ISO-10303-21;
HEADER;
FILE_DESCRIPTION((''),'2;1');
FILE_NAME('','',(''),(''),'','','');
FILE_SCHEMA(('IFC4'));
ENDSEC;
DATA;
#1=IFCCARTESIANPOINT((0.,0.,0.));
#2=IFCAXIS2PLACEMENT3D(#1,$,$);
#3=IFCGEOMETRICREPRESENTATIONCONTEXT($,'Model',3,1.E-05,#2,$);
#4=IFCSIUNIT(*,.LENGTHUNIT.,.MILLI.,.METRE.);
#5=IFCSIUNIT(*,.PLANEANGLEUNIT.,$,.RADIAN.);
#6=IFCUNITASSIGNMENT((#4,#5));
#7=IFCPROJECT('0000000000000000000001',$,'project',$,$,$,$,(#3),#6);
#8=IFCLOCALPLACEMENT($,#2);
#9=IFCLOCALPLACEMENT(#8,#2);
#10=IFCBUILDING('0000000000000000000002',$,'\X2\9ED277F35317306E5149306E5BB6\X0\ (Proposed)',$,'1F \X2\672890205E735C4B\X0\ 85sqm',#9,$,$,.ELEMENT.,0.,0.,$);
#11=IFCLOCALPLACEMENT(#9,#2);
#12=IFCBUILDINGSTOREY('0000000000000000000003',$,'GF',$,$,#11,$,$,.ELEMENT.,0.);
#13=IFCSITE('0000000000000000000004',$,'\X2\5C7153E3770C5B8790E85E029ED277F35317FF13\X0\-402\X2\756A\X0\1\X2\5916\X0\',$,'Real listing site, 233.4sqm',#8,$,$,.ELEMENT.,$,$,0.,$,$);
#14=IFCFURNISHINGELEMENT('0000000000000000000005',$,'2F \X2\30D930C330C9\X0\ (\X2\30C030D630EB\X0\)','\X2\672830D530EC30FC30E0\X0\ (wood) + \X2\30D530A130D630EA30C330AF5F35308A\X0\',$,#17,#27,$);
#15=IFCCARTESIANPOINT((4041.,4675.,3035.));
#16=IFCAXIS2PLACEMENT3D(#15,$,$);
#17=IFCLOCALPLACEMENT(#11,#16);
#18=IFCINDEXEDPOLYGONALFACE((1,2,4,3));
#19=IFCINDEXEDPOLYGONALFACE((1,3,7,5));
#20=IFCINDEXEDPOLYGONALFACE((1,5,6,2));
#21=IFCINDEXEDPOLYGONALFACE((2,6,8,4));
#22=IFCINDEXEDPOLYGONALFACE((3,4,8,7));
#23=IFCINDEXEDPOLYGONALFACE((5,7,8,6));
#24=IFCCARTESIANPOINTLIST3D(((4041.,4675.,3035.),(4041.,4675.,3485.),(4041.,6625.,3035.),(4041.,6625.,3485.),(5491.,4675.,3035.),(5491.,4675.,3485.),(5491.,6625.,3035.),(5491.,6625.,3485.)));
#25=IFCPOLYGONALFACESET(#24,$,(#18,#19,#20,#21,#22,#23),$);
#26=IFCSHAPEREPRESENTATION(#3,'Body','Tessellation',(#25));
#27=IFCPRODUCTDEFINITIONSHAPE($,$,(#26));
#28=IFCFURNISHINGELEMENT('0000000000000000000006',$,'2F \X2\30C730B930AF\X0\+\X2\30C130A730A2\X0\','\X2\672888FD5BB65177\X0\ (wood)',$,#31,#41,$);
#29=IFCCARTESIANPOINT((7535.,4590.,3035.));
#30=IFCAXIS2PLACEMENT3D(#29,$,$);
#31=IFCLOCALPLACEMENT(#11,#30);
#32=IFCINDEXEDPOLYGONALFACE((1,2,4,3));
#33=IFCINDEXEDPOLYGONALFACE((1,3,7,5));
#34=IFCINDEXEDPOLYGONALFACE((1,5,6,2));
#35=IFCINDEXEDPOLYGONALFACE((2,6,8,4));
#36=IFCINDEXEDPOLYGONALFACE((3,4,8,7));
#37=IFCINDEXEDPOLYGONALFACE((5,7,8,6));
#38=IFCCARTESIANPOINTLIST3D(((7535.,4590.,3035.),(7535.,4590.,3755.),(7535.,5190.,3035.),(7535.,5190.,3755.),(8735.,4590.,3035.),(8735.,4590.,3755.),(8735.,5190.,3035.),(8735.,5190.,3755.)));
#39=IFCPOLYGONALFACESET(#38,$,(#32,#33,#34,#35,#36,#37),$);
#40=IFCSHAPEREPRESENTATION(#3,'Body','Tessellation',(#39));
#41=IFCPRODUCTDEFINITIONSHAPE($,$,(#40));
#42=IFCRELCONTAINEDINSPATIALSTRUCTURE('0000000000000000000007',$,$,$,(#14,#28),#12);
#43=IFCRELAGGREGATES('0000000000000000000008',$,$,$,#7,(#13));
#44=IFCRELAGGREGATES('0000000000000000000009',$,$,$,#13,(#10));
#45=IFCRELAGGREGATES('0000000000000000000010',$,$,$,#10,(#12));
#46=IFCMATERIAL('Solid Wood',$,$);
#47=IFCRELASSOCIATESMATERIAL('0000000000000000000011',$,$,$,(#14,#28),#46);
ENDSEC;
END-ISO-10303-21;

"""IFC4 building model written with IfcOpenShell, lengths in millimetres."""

from ifc_helpers import new_model, si_unit, frame, frame_2d, origin, place, context, project, spatial, rectangle, extrude, material, element, save


model = new_model("IFC4")

# Units and contexts
model_context = context("Model", 3, precision=1e-05, world=origin())
ifc_project = project(units=[si_unit("LENGTHUNIT", "METRE", prefix="MILLI"), si_unit("PLANEANGLEUNIT", "RADIAN")], contexts=[model_context])

# Site, building, storey
site_placement = place(None, origin())
site = spatial("IfcSite", under=ifc_project, at=site_placement, Name="山口県宇部市黒石北３-402番1外", ObjectType="Real listing site, 233.4sqm", CompositionType="ELEMENT", RefElevation=0.0)
building_placement = place(site_placement, origin())
building = spatial("IfcBuilding", under=site, at=building_placement, Name="黒石北の光の家 (Proposed)", ObjectType="1F 木造平屋 85sqm", CompositionType="ELEMENT", ElevationOfRefHeight=0.0, ElevationOfTerrain=0.0)
storey_placement = place(building_placement, origin())
storey = spatial("IfcBuildingStorey", under=building, at=storey_placement, Name="GF", CompositionType="ELEMENT", Elevation=0.0)

# Shared definitions
ifc_material_1 = material(Name="Solid Wood")

# Furnishing elements
furnishing_1_placement = place(storey_placement, frame((4041.0, 4675.0, 3035.0)))
element("IfcFurnishingElement", 1, at=furnishing_1_placement, inside=storey, material=ifc_material_1, Name="2F ベッド (ダブル)", Description="木フレーム (wood) + ファブリック張り", context=model_context, shape_type="SweptSolid", body=[
    extrude(rectangle(XDim=1450.0, YDim=1950.0, at=frame_2d((725.0, 975.0))), frame((4041.0, 4675.0, 3035.0)), (0.0, 0.0, 1.0), 450.0),
])
furnishing_2_placement = place(storey_placement, frame((7535.0, 4590.0, 3035.0)))
element("IfcFurnishingElement", 2, at=furnishing_2_placement, inside=storey, material=ifc_material_1, Name="2F デスク+チェア", Description="木製家具 (wood)", context=model_context, shape_type="SweptSolid", body=[
    extrude(rectangle(XDim=1200.0, YDim=600.0, at=frame_2d((600.0, 300.0))), frame((7535.0, 4590.0, 3035.0)), (0.0, 0.0, 1.0), 720.0),
])

save(model, "model.ifc")
